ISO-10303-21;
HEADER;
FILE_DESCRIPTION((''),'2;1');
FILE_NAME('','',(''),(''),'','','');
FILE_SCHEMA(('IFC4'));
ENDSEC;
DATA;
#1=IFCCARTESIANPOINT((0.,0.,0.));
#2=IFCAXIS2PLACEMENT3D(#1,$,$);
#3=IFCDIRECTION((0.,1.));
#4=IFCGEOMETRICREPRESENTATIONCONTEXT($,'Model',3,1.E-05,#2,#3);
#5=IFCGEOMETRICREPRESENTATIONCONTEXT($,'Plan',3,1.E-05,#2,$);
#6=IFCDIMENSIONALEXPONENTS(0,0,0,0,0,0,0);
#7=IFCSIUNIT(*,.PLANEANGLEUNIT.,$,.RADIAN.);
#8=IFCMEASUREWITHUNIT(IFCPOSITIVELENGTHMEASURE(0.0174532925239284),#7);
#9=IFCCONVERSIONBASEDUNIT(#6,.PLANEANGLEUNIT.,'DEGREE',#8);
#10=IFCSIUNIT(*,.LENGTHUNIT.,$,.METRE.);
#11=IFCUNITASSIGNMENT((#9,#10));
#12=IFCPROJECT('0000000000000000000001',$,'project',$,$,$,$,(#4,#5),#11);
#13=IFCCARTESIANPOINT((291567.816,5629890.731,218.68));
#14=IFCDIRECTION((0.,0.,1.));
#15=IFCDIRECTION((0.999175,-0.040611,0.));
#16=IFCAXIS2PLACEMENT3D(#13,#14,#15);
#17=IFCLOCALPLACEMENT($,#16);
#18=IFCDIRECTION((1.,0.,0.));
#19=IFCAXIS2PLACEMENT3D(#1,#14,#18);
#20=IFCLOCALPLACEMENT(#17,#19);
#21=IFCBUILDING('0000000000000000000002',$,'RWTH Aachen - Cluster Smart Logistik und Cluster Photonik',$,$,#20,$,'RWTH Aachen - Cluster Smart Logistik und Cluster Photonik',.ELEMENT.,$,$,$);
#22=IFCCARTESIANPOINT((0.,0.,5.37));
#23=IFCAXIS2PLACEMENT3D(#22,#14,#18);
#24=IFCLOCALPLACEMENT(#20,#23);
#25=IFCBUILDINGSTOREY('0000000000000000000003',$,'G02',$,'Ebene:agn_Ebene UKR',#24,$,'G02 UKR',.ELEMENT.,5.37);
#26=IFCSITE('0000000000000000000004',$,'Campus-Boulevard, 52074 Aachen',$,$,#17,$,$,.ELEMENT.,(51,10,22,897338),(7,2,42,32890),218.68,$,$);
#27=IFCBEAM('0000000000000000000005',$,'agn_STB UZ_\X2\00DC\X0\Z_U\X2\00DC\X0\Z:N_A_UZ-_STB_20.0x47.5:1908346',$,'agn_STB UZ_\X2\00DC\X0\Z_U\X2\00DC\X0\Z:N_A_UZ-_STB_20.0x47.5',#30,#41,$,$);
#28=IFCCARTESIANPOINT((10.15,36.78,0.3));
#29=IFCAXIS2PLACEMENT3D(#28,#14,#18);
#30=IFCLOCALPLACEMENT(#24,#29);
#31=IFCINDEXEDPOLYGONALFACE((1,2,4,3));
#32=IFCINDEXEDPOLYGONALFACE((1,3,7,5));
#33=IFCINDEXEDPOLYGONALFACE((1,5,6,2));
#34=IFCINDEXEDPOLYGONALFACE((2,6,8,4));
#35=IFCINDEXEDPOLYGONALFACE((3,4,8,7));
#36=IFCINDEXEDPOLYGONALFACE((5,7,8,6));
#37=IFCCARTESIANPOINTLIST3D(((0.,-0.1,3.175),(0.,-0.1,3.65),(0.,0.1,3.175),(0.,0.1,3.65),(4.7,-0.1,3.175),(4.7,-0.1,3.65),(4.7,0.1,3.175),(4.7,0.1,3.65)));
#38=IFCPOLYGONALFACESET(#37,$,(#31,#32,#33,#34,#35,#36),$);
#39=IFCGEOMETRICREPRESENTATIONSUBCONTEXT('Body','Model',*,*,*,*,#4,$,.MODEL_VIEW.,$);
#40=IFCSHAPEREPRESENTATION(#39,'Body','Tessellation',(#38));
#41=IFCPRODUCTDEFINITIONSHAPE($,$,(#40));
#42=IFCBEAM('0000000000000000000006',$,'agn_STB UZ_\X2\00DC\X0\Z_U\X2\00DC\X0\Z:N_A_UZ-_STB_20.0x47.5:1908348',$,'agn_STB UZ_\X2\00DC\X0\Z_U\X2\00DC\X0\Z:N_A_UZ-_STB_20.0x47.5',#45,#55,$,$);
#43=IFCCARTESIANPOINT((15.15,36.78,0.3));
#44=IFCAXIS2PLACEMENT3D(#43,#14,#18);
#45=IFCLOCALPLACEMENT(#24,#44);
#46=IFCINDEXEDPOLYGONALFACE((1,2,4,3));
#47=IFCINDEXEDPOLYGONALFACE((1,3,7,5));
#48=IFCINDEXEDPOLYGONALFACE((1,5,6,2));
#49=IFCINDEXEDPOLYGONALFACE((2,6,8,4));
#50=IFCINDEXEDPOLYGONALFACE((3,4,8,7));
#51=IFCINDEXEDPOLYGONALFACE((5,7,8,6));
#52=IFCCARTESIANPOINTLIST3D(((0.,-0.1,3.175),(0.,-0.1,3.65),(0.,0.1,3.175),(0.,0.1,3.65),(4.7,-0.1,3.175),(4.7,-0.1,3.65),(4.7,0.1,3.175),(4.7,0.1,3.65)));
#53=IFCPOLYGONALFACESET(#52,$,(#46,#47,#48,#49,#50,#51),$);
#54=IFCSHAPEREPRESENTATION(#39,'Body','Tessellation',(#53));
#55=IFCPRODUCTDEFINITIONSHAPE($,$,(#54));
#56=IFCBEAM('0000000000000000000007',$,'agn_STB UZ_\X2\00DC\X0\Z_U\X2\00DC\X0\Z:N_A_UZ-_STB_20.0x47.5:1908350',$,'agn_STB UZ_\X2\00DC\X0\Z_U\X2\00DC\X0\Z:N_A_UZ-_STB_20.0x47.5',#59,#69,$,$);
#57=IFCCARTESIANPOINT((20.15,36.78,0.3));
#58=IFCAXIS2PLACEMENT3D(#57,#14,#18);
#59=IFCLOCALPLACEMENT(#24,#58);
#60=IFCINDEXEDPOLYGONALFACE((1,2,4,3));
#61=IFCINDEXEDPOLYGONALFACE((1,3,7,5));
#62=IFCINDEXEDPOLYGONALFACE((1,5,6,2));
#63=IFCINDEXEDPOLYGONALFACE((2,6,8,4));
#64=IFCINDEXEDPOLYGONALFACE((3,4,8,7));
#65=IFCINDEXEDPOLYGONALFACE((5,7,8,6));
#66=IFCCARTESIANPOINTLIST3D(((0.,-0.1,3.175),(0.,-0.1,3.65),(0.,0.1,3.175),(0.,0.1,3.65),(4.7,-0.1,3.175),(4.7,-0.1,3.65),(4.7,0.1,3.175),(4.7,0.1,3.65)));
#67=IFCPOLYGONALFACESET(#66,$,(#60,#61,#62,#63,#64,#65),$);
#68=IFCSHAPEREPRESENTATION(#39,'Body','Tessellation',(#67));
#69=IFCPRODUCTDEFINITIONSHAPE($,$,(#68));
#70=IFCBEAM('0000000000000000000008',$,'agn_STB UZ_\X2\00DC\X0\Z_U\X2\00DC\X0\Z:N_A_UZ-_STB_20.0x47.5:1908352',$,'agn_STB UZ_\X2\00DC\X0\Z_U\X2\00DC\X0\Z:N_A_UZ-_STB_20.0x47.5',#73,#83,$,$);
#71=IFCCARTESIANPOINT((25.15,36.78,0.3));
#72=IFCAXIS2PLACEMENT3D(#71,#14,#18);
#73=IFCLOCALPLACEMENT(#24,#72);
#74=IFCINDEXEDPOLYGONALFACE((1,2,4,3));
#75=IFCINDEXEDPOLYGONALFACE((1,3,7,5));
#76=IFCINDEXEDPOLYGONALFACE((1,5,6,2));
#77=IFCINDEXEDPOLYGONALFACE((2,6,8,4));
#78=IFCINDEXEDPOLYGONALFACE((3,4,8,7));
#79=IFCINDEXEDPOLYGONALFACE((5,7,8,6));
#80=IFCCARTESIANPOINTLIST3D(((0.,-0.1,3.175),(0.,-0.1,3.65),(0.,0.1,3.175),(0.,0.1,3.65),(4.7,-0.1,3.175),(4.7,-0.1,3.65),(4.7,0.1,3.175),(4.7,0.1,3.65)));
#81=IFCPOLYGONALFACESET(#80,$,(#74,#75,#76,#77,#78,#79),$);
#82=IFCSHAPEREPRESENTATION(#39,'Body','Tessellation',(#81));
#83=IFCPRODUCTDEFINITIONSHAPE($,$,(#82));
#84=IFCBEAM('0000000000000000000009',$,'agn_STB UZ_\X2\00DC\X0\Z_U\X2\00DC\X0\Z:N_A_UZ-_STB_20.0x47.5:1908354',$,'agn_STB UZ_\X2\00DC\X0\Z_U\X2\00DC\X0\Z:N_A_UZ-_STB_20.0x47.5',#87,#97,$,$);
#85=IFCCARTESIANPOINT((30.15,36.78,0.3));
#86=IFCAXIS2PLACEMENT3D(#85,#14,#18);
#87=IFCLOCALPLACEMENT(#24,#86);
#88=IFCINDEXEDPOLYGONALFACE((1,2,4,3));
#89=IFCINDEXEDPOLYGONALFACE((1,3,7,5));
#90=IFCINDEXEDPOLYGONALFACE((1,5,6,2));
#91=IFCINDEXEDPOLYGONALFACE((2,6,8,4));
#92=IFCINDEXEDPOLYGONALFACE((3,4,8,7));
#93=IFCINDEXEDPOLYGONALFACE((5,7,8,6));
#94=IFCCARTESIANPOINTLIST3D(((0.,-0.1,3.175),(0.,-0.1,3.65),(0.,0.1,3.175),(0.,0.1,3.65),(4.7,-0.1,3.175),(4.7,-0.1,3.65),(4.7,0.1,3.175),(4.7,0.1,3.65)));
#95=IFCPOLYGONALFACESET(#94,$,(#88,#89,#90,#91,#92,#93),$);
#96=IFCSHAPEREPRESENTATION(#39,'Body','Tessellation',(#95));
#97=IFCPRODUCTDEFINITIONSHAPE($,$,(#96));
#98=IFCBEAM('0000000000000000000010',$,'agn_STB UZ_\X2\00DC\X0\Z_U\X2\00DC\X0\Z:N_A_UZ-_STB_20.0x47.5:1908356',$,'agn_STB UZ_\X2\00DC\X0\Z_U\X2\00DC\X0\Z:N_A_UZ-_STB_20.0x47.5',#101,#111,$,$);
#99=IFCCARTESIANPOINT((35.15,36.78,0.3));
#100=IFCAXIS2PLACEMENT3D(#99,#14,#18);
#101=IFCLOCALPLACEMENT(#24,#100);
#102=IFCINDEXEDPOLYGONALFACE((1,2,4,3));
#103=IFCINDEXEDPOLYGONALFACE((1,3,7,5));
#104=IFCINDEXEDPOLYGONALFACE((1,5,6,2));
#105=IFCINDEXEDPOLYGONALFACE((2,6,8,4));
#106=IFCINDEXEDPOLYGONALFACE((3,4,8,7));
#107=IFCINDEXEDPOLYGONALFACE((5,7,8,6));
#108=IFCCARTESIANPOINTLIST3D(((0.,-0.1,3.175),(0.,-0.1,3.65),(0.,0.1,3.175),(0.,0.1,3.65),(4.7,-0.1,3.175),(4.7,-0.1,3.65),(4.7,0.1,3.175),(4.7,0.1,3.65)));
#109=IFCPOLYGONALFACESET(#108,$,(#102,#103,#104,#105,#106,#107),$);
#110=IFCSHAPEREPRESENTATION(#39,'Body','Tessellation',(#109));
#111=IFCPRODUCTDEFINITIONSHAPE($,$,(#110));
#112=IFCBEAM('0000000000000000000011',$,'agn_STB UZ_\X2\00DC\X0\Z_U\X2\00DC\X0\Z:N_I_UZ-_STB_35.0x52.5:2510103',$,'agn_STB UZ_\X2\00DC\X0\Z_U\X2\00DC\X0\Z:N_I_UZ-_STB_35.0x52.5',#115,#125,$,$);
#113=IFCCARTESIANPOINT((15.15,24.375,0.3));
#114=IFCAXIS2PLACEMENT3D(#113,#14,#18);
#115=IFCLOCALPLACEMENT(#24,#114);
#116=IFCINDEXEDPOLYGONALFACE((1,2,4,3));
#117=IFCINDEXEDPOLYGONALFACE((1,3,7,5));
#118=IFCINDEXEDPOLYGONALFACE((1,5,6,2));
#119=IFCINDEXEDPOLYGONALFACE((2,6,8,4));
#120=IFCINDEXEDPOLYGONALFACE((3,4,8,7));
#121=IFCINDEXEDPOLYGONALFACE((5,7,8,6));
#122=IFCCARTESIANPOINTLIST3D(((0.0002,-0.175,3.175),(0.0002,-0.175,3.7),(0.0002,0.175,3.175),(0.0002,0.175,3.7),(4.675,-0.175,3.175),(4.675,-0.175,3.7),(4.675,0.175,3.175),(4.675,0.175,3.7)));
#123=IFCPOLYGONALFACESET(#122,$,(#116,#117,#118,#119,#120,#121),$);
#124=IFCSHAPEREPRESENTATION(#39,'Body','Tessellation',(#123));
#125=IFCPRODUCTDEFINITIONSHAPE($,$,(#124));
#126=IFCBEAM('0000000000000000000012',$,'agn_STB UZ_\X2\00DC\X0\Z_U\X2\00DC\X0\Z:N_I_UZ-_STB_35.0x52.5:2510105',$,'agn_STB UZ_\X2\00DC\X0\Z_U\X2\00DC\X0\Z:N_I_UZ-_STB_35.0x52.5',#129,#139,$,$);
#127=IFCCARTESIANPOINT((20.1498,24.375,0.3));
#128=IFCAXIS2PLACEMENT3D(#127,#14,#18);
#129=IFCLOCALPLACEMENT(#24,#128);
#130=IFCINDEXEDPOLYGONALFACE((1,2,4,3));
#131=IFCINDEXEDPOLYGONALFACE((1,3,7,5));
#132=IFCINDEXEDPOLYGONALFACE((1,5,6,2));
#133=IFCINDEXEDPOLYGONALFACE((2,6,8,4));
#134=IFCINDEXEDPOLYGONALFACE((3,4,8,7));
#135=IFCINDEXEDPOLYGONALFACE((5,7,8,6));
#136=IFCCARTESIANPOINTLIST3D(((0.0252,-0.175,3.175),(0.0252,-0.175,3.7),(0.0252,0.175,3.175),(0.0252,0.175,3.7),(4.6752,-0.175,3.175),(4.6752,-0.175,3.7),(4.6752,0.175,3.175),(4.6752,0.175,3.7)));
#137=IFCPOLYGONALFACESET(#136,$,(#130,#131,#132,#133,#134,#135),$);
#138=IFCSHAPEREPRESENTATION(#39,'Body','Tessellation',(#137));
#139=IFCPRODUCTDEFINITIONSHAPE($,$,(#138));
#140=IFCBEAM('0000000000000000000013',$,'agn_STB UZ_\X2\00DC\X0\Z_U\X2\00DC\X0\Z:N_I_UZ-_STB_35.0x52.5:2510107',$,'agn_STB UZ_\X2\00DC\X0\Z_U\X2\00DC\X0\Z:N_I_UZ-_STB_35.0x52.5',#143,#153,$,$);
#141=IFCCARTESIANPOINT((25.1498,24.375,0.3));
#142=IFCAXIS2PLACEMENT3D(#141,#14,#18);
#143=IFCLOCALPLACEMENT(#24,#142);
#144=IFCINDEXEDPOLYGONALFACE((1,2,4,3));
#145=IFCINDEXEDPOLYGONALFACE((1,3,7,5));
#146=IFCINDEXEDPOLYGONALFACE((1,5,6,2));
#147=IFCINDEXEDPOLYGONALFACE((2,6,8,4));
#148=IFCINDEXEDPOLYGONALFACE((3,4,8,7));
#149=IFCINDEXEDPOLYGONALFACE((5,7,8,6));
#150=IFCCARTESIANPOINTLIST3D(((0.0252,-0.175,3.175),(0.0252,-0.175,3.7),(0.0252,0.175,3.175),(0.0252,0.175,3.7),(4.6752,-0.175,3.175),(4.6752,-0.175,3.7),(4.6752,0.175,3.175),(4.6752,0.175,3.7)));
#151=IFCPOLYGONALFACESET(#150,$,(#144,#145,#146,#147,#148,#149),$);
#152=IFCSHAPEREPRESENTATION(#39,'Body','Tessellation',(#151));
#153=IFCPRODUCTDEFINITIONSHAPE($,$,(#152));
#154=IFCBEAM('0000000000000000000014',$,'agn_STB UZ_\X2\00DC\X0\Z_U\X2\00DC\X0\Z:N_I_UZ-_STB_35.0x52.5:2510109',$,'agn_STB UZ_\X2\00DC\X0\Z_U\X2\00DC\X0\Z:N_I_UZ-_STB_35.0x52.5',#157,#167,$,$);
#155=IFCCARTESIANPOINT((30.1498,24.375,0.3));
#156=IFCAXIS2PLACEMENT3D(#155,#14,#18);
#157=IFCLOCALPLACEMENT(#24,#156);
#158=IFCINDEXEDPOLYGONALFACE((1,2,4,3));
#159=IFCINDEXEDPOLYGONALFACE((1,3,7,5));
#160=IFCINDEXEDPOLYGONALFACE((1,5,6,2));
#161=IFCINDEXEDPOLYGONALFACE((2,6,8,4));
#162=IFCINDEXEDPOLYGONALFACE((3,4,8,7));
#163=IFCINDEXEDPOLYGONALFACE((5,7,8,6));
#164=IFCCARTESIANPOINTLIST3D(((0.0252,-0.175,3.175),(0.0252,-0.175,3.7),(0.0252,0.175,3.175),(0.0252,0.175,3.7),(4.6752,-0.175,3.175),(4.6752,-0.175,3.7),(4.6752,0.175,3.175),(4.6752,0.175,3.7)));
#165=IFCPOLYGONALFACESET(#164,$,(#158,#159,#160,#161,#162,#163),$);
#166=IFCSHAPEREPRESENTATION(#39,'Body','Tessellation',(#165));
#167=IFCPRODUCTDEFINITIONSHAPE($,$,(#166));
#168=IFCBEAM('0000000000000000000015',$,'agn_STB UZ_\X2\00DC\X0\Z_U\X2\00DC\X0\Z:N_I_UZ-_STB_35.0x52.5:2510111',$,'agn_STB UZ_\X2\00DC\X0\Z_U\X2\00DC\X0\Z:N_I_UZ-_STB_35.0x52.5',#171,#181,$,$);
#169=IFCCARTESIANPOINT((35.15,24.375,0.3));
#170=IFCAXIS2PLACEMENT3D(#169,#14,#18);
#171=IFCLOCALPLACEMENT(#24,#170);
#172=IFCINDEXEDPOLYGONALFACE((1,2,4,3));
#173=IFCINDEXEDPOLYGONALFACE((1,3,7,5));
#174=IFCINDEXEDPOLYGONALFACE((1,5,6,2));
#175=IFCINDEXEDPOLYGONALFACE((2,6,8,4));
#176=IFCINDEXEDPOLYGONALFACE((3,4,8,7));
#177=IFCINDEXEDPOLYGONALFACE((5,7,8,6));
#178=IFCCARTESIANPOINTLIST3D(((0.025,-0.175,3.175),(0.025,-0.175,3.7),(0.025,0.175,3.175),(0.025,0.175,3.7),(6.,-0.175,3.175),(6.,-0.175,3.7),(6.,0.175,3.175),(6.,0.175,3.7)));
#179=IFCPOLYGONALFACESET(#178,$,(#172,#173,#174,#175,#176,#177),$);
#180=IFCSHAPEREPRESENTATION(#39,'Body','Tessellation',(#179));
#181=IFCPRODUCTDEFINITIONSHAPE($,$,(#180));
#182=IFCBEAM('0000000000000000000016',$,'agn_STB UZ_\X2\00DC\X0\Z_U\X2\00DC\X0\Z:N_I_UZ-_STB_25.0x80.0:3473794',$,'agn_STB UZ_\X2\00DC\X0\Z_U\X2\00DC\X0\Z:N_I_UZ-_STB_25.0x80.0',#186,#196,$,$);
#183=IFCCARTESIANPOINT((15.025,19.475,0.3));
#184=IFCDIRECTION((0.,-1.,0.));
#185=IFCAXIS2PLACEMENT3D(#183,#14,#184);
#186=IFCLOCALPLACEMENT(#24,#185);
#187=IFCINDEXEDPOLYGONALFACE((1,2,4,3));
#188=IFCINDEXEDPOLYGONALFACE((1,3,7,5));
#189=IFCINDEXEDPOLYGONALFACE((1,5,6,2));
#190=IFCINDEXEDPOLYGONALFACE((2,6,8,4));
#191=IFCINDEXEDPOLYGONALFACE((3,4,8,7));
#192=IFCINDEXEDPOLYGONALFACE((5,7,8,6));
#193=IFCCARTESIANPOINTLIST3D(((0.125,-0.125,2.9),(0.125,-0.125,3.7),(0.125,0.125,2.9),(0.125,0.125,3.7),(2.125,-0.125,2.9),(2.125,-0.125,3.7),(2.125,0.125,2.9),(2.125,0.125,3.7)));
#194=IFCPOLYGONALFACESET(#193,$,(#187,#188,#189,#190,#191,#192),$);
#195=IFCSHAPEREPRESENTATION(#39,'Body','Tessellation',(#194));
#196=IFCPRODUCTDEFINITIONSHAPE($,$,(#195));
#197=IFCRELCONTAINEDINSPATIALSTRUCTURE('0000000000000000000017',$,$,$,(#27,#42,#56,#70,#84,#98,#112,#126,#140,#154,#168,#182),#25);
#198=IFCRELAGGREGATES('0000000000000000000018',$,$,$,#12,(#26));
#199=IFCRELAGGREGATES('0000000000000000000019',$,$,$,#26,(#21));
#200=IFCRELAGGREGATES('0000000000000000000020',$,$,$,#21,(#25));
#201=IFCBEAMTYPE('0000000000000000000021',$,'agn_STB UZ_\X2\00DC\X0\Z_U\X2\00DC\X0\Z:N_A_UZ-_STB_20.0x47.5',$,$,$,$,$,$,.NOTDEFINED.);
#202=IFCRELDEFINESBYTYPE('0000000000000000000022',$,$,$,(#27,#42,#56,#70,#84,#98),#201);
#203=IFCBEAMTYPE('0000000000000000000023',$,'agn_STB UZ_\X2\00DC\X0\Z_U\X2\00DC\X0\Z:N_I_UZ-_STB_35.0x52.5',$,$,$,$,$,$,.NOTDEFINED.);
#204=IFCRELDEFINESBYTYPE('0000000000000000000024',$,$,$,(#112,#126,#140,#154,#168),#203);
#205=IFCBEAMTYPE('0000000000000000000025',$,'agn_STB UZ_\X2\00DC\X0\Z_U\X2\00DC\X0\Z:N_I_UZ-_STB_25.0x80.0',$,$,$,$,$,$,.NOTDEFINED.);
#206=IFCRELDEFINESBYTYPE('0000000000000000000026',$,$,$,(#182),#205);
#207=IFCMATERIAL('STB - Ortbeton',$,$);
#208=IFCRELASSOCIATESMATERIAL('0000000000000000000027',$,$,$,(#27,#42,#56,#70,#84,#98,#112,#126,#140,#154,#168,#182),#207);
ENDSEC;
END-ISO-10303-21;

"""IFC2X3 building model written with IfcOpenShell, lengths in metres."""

from ifc_helpers import new_model, entity, si_unit, converted_unit, direction, frame, frame_2d, origin, origin_with_axes, origin_2d_with_axis, place, context, subcontext, project, spatial, rectangle, extrude, material, type_object, element, save


model = new_model("IFC2X3")

# Units and contexts
model_context = context("Model", 3, precision=1e-05, world=origin(), true_north=direction((0.0, 1.0)))
plan_context = context("Plan", 3, precision=1e-05, world=origin())
body_context = subcontext(model_context, "Body", "Model", "MODEL_VIEW")
ifc_project = project(units=[converted_unit("PLANEANGLEUNIT", "DEGREE", entity("IfcPositiveLengthMeasure", 0.0174532925239284), si_unit("PLANEANGLEUNIT", "RADIAN"), dimensions=[0, 0, 0, 0, 0, 0, 0]), si_unit("LENGTHUNIT", "METRE")], contexts=[model_context, plan_context])

# Site, building, storey
site_placement = place(None, frame((291567.816, 5629890.731, 218.68), z_axis=(0.0, 0.0, 1.0), x_axis=(0.999175, -0.040611, 0.0)))
site = spatial("IfcSite", under=ifc_project, at=site_placement, Name="Campus-Boulevard, 52074 Aachen", CompositionType="ELEMENT", RefLatitude=(51, 10, 22, 897338), RefLongitude=(7, 2, 42, 32890), RefElevation=218.68)
building_placement = place(site_placement, origin_with_axes())
building = spatial("IfcBuilding", under=site, at=building_placement, Name="RWTH Aachen - Cluster Smart Logistik und Cluster Photonik", LongName="RWTH Aachen - Cluster Smart Logistik und Cluster Photonik", CompositionType="ELEMENT")
storey_placement = place(building_placement, frame((0.0, 0.0, 5.37), z_axis=(0.0, 0.0, 1.0), x_axis=(1.0, 0.0, 0.0)))
storey = spatial("IfcBuildingStorey", under=building, at=storey_placement, Name="G02", ObjectType="Ebene:agn_Ebene UKR", LongName="G02 UKR", CompositionType="ELEMENT", Elevation=5.37)

# Beams
ifc_material_1 = material(Name="STB - Ortbeton")
beam_type_1 = type_object("IfcBeamType", Name="agn_STB UZ_ÜZ_UÜZ:N_A_UZ-_STB_20.0x47.5", PredefinedType="NOTDEFINED")
for number, where, z_axis, x_axis, name in (
    (1, (10.15, 36.78, 0.3), (0.0, 0.0, 1.0), (1.0, 0.0, 0.0), "agn_STB UZ_ÜZ_UÜZ:N_A_UZ-_STB_20.0x47.5:1908346"),
    (2, (15.15, 36.78, 0.3), (0.0, 0.0, 1.0), (1.0, 0.0, 0.0), "agn_STB UZ_ÜZ_UÜZ:N_A_UZ-_STB_20.0x47.5:1908348"),
    (3, (20.15, 36.78, 0.3), (0.0, 0.0, 1.0), (1.0, 0.0, 0.0), "agn_STB UZ_ÜZ_UÜZ:N_A_UZ-_STB_20.0x47.5:1908350"),
    (4, (25.15, 36.78, 0.3), (0.0, 0.0, 1.0), (1.0, 0.0, 0.0), "agn_STB UZ_ÜZ_UÜZ:N_A_UZ-_STB_20.0x47.5:1908352"),
    (5, (30.15, 36.78, 0.3), (0.0, 0.0, 1.0), (1.0, 0.0, 0.0), "agn_STB UZ_ÜZ_UÜZ:N_A_UZ-_STB_20.0x47.5:1908354"),
    (6, (35.15, 36.78, 0.3), (0.0, 0.0, 1.0), (1.0, 0.0, 0.0), "agn_STB UZ_ÜZ_UÜZ:N_A_UZ-_STB_20.0x47.5:1908356"),
):
    element("IfcBeam", number, at=place(storey_placement, frame(where, z_axis=z_axis, x_axis=x_axis)), inside=storey, type_object=beam_type_1, material=ifc_material_1, Name=name, ObjectType="agn_STB UZ_ÜZ_UÜZ:N_A_UZ-_STB_20.0x47.5", context=body_context, shape_type="SweptSolid", body=[
        extrude(rectangle(XDim=0.475, YDim=0.2, at=frame_2d((0.0, 0.0), x_axis=(1.0, 0.0))), frame((0.0, 0.0, 3.4125), z_axis=(1.0, 0.0, 0.0), x_axis=(0.0, 0.0, -1.0)), (0.0, 0.0, 1.0), 4.7),
    ])
beam_type_2 = type_object("IfcBeamType", Name="agn_STB UZ_ÜZ_UÜZ:N_I_UZ-_STB_35.0x52.5", PredefinedType="NOTDEFINED")
beam_1_placement = place(storey_placement, frame((15.15, 24.375, 0.3), z_axis=(0.0, 0.0, 1.0), x_axis=(1.0, 0.0, 0.0)))
element("IfcBeam", 7, at=beam_1_placement, inside=storey, type_object=beam_type_2, material=ifc_material_1, Name="agn_STB UZ_ÜZ_UÜZ:N_I_UZ-_STB_35.0x52.5:2510103", ObjectType="agn_STB UZ_ÜZ_UÜZ:N_I_UZ-_STB_35.0x52.5", context=body_context, shape_type="SweptSolid", body=[
    extrude(rectangle(XDim=0.525, YDim=0.35, at=frame_2d((0.0, 0.0), x_axis=(1.0, 0.0))), frame((0.0002, 0.0, 3.4375), z_axis=(1.0, 0.0, 0.0), x_axis=(0.0, 0.0, -1.0)), (0.0, 0.0, 1.0), 4.6747),
])
beam_2_placement = place(storey_placement, frame((20.1498, 24.375, 0.3), z_axis=(0.0, 0.0, 1.0), x_axis=(1.0, 0.0, 0.0)))
element("IfcBeam", 8, at=beam_2_placement, inside=storey, type_object=beam_type_2, material=ifc_material_1, Name="agn_STB UZ_ÜZ_UÜZ:N_I_UZ-_STB_35.0x52.5:2510105", ObjectType="agn_STB UZ_ÜZ_UÜZ:N_I_UZ-_STB_35.0x52.5", context=body_context, shape_type="SweptSolid", body=[
    extrude(rectangle(XDim=0.525, YDim=0.35, at=frame_2d((0.0, 0.0), x_axis=(1.0, 0.0))), frame((0.0252, 0.0, 3.4375), z_axis=(1.0, 0.0, 0.0), x_axis=(0.0, 0.0, -1.0)), (0.0, 0.0, 1.0), 4.65),
])
for number, where, z_axis, x_axis, name in (
    (9, (25.1498, 24.375, 0.3), (0.0, 0.0, 1.0), (1.0, 0.0, 0.0), "agn_STB UZ_ÜZ_UÜZ:N_I_UZ-_STB_35.0x52.5:2510107"),
    (10, (30.1498, 24.375, 0.3), (0.0, 0.0, 1.0), (1.0, 0.0, 0.0), "agn_STB UZ_ÜZ_UÜZ:N_I_UZ-_STB_35.0x52.5:2510109"),
):
    element("IfcBeam", number, at=place(storey_placement, frame(where, z_axis=z_axis, x_axis=x_axis)), inside=storey, type_object=beam_type_2, material=ifc_material_1, Name=name, ObjectType="agn_STB UZ_ÜZ_UÜZ:N_I_UZ-_STB_35.0x52.5", context=body_context, shape_type="SweptSolid", body=[
        extrude(rectangle(XDim=0.525, YDim=0.35, at=frame_2d((0.0, 0.0), x_axis=(1.0, 0.0))), frame((0.0252, 0.0, 3.4375), z_axis=(1.0, 0.0, 0.0), x_axis=(0.0, 0.0, -1.0)), (0.0, 0.0, 1.0), 4.65),
    ])
beam_3_placement = place(storey_placement, frame((35.15, 24.375, 0.3), z_axis=(0.0, 0.0, 1.0), x_axis=(1.0, 0.0, 0.0)))
element("IfcBeam", 11, at=beam_3_placement, inside=storey, type_object=beam_type_2, material=ifc_material_1, Name="agn_STB UZ_ÜZ_UÜZ:N_I_UZ-_STB_35.0x52.5:2510111", ObjectType="agn_STB UZ_ÜZ_UÜZ:N_I_UZ-_STB_35.0x52.5", context=body_context, shape_type="SweptSolid", body=[
    extrude(rectangle(XDim=0.525, YDim=0.35, at=frame_2d((0.0, 0.0), x_axis=(1.0, 0.0))), frame((0.025, 0.0, 3.4375), z_axis=(1.0, 0.0, 0.0), x_axis=(0.0, 0.0, -1.0)), (0.0, 0.0, 1.0), 5.975),
])
beam_type_3 = type_object("IfcBeamType", Name="agn_STB UZ_ÜZ_UÜZ:N_I_UZ-_STB_25.0x80.0", PredefinedType="NOTDEFINED")
beam_4_placement = place(storey_placement, frame((15.025, 19.475, 0.3), z_axis=(0.0, 0.0, 1.0), x_axis=(0.0, -1.0, 0.0)))
element("IfcBeam", 12, at=beam_4_placement, inside=storey, type_object=beam_type_3, material=ifc_material_1, Name="agn_STB UZ_ÜZ_UÜZ:N_I_UZ-_STB_25.0x80.0:3473794", ObjectType="agn_STB UZ_ÜZ_UÜZ:N_I_UZ-_STB_25.0x80.0", context=body_context, shape_type="SweptSolid", body=[
    extrude(rectangle(XDim=0.8, YDim=0.25, at=origin_2d_with_axis()), frame((0.125, 0.0, 3.3), z_axis=(1.0, 0.0, 0.0), x_axis=(0.0, 0.0, -1.0)), (0.0, 0.0, 1.0), 2.0),
])

save(model, "model.ifc")
